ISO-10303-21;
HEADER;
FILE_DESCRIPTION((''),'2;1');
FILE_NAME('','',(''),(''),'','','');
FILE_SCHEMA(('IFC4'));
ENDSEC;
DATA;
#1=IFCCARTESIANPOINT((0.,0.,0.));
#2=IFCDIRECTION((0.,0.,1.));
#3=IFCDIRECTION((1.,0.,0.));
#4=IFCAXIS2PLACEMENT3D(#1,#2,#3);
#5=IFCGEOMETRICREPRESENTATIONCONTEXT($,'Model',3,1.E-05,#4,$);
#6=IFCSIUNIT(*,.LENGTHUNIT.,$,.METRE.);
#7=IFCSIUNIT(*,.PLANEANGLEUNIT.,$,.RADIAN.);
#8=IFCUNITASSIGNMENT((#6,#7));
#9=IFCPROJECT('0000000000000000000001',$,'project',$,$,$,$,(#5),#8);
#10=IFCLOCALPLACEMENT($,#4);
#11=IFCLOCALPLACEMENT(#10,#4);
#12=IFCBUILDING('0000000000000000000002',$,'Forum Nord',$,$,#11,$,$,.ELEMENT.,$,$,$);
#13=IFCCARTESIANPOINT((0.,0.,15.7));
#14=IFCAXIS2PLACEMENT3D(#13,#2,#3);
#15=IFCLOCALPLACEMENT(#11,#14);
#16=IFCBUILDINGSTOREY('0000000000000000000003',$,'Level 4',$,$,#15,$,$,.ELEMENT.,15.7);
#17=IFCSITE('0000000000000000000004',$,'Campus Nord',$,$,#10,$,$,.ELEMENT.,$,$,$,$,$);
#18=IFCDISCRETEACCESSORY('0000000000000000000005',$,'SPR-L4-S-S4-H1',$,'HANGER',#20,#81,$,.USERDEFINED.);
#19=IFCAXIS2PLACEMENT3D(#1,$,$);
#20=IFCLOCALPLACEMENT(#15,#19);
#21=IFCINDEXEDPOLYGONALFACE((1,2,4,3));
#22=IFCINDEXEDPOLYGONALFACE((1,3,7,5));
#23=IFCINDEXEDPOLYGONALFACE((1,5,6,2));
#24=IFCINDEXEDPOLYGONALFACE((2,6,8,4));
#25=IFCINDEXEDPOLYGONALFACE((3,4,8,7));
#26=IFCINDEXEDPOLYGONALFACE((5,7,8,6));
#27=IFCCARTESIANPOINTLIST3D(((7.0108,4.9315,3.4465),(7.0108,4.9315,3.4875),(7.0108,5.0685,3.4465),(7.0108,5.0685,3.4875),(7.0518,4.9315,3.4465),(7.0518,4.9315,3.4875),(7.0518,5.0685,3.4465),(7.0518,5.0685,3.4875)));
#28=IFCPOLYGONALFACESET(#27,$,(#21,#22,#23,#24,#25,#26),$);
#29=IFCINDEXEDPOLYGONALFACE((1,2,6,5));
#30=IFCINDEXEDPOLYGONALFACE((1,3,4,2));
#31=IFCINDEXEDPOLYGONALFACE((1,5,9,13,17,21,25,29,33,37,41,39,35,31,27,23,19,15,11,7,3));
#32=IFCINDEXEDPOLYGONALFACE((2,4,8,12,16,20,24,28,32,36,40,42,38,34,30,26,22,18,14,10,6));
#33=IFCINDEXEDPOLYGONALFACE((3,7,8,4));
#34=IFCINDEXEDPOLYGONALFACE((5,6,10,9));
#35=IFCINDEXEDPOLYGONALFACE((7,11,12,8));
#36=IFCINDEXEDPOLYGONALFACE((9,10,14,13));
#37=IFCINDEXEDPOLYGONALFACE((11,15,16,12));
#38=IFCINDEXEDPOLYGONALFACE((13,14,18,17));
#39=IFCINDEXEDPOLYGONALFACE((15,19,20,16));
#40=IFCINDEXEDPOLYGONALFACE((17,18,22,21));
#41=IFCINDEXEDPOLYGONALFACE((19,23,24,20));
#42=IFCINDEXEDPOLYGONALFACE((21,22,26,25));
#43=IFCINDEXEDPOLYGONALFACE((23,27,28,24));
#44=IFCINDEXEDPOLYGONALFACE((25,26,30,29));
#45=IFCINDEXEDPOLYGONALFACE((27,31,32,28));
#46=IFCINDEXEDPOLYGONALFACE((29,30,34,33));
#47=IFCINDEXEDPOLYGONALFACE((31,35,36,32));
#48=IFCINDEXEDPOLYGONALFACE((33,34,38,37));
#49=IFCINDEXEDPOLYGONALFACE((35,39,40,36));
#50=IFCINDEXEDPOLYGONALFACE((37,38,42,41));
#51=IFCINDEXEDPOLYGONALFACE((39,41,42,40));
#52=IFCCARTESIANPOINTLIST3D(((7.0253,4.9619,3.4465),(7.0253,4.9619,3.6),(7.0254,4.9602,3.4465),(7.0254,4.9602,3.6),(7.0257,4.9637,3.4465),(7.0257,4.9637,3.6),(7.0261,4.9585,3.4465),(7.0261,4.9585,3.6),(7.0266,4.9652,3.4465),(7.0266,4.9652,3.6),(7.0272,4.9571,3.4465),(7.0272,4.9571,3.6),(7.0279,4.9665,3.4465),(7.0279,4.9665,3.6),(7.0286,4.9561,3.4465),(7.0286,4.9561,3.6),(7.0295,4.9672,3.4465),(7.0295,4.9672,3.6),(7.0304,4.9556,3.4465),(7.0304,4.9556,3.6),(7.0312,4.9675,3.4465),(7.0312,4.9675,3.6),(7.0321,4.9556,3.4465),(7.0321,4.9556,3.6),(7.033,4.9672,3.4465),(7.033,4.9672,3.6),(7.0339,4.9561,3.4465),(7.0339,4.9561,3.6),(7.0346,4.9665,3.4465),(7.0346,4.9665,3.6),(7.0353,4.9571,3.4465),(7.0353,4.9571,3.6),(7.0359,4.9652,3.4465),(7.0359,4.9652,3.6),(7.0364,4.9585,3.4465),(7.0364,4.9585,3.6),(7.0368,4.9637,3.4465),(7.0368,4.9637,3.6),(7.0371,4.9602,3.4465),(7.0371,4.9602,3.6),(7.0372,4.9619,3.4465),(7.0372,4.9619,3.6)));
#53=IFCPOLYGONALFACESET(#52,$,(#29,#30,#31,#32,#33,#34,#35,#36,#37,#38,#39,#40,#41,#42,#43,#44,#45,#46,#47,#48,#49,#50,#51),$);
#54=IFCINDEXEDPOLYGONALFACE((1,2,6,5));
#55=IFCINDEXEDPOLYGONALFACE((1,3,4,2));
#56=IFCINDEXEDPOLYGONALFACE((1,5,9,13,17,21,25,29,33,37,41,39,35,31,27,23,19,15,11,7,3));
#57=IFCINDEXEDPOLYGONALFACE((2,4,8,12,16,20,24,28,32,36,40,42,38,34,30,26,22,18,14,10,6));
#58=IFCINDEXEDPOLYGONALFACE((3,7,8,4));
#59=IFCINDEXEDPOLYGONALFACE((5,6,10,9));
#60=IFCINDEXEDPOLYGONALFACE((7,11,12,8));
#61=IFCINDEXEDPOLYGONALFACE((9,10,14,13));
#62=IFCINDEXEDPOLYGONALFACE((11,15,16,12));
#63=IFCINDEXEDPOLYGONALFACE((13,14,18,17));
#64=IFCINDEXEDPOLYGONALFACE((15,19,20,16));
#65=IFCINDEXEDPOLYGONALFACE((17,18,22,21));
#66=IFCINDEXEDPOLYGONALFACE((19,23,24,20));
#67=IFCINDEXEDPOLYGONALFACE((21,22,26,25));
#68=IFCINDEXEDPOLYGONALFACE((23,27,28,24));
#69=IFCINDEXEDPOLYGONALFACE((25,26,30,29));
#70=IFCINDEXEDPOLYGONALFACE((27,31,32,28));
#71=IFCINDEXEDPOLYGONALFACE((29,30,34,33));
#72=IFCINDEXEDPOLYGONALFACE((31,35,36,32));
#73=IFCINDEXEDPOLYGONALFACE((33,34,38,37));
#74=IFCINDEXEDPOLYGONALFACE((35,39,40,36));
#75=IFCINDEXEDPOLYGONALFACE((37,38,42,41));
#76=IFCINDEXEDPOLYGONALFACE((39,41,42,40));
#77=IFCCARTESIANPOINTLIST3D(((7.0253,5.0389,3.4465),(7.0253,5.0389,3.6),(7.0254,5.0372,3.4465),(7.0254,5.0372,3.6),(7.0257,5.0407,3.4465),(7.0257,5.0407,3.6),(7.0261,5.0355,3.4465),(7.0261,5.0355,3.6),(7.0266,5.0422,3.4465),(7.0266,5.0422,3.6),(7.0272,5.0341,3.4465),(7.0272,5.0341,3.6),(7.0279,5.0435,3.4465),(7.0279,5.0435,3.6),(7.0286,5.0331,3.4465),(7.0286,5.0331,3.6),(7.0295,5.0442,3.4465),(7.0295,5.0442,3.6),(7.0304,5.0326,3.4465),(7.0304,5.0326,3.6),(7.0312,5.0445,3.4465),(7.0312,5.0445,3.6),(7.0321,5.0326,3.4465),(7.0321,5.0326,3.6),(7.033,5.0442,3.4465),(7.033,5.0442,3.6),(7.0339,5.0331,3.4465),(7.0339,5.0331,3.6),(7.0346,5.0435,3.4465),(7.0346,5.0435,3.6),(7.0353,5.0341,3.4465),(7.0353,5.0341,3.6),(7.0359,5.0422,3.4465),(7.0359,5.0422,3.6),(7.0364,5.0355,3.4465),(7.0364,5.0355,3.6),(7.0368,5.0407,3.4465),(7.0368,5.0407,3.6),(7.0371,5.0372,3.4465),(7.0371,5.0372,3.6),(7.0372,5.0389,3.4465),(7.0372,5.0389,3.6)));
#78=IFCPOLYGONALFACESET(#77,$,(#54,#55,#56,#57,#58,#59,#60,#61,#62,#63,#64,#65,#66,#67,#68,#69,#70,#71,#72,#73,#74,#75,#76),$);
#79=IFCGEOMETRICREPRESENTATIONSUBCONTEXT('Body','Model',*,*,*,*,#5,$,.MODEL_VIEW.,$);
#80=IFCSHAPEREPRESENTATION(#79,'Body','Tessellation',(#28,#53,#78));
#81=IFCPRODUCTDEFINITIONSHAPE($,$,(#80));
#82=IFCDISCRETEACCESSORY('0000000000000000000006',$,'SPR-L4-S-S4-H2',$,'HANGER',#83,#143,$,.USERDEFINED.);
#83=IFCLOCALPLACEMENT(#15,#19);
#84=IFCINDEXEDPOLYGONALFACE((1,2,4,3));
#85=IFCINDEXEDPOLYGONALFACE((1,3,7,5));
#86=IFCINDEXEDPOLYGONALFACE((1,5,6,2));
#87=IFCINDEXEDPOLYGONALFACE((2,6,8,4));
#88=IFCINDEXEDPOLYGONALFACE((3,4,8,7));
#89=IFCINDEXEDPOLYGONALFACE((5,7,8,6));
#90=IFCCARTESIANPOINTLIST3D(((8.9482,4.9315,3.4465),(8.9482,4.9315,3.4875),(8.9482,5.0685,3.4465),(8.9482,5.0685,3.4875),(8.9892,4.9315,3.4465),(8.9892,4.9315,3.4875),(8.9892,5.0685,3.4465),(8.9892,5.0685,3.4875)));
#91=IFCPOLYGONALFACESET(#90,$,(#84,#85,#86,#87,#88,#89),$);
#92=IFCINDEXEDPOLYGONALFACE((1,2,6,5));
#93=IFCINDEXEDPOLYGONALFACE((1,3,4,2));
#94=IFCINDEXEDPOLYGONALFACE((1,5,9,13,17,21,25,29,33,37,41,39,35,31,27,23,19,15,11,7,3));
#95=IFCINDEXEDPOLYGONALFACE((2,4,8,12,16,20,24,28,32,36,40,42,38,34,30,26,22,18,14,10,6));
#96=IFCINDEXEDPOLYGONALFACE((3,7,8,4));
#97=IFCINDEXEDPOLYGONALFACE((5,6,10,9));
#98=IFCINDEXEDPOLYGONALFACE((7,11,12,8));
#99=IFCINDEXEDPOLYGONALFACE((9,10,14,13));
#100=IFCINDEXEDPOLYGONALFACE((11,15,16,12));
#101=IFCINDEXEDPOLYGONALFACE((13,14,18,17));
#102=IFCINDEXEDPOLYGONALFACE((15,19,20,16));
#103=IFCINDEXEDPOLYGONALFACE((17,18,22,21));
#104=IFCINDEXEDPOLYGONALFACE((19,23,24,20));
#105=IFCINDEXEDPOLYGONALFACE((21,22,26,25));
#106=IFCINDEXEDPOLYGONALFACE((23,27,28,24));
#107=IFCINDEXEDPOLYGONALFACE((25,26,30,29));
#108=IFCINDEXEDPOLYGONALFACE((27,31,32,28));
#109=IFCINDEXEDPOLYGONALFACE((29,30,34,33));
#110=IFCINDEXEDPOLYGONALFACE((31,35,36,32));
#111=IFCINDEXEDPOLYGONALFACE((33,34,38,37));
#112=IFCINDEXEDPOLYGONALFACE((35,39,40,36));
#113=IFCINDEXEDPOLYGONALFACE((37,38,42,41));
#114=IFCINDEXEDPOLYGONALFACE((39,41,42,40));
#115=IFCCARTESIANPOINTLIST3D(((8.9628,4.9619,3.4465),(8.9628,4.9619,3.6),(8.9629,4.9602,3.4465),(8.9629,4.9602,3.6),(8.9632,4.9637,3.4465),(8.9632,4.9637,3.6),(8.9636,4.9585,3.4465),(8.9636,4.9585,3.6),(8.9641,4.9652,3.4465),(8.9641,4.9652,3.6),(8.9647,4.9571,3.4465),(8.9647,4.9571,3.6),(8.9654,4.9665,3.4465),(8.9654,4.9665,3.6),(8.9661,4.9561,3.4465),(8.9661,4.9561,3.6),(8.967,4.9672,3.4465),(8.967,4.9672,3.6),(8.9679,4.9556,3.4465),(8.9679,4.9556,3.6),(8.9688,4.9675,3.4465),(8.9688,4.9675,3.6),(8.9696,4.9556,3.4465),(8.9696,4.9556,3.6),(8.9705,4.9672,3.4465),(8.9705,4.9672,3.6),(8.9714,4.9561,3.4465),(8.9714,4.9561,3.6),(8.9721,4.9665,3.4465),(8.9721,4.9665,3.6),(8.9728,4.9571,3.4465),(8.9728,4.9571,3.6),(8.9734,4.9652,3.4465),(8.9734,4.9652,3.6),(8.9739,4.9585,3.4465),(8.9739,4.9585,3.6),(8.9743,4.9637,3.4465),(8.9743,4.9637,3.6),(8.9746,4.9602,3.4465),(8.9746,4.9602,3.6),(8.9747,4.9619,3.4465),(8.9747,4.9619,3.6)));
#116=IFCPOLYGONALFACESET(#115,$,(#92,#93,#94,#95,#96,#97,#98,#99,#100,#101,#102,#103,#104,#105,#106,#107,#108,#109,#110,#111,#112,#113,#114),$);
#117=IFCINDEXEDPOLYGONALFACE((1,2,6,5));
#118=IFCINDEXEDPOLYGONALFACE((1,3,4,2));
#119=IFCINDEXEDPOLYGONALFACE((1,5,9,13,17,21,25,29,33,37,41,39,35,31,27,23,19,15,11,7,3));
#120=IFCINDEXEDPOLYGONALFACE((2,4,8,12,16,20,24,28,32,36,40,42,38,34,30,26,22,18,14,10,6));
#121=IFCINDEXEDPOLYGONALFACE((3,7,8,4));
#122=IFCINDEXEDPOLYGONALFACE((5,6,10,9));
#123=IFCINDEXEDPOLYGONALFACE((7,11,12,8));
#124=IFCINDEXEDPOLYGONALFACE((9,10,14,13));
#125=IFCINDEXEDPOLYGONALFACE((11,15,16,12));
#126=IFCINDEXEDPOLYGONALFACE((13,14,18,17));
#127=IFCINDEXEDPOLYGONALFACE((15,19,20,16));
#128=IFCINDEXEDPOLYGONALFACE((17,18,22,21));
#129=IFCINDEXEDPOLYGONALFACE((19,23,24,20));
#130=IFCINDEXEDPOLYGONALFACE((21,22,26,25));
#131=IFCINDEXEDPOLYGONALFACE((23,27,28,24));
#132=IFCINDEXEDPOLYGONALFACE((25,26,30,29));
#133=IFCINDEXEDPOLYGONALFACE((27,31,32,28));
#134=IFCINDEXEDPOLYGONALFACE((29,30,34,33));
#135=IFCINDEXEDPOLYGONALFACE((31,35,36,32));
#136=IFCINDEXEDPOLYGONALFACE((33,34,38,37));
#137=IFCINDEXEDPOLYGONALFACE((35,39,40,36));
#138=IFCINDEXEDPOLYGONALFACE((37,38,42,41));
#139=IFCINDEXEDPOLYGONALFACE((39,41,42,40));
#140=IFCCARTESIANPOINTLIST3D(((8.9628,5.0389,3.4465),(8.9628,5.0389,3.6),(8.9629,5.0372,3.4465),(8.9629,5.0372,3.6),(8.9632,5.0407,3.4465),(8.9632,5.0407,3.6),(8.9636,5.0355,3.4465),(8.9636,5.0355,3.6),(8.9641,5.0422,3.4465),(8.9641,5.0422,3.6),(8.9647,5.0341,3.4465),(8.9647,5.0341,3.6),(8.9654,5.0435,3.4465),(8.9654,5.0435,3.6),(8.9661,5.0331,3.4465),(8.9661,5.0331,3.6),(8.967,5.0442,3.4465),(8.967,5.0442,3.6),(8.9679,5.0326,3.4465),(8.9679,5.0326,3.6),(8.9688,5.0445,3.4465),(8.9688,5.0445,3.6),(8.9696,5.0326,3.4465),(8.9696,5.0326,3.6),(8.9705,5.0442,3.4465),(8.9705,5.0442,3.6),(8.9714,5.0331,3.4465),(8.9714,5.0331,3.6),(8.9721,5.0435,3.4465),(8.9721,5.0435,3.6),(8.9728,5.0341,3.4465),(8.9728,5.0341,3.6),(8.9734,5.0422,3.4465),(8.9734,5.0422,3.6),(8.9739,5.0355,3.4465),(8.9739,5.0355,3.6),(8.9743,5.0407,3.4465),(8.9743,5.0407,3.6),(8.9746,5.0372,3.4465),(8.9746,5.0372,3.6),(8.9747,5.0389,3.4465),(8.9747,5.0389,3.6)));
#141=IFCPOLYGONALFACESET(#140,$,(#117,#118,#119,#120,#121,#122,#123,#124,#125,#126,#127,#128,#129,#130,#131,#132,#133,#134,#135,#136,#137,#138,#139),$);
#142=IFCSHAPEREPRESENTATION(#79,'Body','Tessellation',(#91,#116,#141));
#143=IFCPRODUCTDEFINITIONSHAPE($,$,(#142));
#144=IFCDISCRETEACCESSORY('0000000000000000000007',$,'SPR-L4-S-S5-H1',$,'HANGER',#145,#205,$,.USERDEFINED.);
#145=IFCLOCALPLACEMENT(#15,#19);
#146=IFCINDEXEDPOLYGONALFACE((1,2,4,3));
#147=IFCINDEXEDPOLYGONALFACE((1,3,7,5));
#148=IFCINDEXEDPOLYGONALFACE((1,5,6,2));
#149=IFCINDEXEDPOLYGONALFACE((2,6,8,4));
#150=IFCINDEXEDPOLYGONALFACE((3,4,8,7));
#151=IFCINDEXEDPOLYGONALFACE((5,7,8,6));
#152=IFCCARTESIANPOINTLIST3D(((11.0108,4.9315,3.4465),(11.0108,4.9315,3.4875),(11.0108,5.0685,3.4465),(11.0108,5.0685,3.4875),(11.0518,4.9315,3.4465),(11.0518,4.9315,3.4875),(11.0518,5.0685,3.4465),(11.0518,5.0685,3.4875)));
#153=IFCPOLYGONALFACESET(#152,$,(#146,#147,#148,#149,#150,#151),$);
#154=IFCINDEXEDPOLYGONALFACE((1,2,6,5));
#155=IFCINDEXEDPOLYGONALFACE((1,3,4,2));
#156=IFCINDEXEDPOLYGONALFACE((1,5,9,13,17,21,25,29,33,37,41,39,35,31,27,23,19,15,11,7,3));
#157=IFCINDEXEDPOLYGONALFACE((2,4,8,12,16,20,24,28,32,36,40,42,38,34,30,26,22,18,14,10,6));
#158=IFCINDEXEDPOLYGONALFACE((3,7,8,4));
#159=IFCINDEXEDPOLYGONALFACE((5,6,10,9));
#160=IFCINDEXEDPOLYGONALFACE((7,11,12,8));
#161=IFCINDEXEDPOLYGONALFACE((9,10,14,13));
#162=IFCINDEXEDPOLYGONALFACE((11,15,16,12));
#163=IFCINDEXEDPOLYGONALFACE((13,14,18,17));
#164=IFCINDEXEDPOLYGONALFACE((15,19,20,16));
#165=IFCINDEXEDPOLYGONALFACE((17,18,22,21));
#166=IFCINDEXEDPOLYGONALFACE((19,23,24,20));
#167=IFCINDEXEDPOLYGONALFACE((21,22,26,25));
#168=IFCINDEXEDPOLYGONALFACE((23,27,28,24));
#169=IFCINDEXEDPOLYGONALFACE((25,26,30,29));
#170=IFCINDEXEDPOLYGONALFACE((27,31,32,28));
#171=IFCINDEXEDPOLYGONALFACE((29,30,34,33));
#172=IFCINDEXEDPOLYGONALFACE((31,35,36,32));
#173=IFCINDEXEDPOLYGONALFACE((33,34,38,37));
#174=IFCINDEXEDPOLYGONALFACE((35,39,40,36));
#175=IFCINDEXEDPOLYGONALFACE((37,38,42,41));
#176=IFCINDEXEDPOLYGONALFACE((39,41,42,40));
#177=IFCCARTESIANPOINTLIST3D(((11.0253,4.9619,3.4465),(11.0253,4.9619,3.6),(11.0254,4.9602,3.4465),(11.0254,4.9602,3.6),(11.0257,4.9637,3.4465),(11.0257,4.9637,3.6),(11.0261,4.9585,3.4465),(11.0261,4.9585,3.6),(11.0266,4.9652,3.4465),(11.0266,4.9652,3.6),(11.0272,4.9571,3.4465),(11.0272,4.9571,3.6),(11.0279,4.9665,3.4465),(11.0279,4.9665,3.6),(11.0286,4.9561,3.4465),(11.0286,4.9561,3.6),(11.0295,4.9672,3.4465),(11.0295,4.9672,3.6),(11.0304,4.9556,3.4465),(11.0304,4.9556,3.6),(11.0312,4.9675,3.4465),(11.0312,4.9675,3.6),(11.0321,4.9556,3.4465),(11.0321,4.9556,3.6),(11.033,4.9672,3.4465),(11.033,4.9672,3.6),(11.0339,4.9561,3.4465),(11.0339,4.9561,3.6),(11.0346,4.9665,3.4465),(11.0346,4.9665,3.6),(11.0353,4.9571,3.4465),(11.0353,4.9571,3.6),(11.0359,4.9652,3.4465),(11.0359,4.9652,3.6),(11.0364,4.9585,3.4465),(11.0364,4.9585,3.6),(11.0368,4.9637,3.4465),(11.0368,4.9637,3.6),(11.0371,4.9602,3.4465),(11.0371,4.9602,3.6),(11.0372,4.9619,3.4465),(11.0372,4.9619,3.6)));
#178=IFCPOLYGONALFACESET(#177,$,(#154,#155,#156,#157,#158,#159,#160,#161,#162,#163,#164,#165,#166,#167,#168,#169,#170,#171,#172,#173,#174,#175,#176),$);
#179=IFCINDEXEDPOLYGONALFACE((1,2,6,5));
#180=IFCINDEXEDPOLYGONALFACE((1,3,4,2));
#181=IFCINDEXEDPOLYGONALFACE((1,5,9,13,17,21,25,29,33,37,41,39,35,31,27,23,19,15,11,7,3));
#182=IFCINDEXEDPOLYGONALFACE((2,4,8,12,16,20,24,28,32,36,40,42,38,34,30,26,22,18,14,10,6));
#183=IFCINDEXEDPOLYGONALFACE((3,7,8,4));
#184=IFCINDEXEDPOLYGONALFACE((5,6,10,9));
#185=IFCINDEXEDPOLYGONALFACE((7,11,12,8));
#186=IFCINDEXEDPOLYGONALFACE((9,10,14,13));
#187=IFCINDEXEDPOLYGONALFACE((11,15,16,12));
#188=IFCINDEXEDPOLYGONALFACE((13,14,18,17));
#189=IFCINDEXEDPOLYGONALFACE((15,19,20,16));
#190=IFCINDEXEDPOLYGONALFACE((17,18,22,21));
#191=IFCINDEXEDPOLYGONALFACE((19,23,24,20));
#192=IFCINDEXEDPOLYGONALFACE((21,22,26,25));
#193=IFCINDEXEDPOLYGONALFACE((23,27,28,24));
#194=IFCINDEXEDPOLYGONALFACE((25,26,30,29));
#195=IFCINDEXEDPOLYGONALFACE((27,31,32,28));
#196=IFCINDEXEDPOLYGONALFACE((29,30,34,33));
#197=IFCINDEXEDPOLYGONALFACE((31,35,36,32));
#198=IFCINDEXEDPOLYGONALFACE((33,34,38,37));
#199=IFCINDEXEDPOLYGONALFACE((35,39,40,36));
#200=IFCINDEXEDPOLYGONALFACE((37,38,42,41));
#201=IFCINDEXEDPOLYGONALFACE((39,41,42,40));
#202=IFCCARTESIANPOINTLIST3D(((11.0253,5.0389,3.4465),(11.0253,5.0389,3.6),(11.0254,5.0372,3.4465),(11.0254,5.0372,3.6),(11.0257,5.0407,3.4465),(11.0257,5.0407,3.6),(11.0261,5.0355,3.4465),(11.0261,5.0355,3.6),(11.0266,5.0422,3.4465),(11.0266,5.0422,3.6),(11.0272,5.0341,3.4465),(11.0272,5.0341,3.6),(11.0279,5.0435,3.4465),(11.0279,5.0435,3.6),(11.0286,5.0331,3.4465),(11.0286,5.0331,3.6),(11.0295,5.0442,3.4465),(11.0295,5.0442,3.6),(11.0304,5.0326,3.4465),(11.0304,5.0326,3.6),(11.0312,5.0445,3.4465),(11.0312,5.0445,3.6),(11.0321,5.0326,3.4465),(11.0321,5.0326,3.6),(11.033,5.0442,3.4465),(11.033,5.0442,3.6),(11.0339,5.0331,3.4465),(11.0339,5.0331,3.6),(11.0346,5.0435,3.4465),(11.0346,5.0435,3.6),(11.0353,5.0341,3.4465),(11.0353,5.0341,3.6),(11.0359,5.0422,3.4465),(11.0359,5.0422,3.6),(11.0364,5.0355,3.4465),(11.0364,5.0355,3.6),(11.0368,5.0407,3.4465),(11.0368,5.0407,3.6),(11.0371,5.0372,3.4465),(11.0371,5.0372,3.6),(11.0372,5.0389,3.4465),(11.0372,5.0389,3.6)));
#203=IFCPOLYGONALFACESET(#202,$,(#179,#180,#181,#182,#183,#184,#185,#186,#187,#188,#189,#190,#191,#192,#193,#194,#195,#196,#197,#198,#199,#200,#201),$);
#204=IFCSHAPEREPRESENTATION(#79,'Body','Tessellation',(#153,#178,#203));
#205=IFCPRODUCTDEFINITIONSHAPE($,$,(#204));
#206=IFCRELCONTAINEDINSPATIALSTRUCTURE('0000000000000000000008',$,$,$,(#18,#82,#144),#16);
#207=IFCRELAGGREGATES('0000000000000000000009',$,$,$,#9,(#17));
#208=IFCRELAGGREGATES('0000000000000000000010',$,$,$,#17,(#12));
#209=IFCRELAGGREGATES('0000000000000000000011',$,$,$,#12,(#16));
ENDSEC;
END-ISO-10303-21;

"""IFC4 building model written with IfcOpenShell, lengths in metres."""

from ifc_helpers import new_model, si_unit, frame, frame_2d, origin_with_axes, origin_2d_with_axis, place, context, subcontext, project, spatial, rectangle, circle, extrude, element, save


model = new_model("IFC4")

# Units and contexts
model_context = context("Model", 3, precision=1e-05, world=origin_with_axes())
body_context = subcontext(model_context, "Body", "Model", "MODEL_VIEW")
ifc_project = project(units=[si_unit("LENGTHUNIT", "METRE"), si_unit("PLANEANGLEUNIT", "RADIAN")], contexts=[model_context])

# Site, building, storey
site_placement = place(None, origin_with_axes())
site = spatial("IfcSite", under=ifc_project, at=site_placement, Name="Campus Nord", CompositionType="ELEMENT")
building_placement = place(site_placement, origin_with_axes())
building = spatial("IfcBuilding", under=site, at=building_placement, Name="Forum Nord", CompositionType="ELEMENT")
storey_placement = place(building_placement, frame((0.0, 0.0, 15.7), z_axis=(0.0, 0.0, 1.0), x_axis=(1.0, 0.0, 0.0)))
storey = spatial("IfcBuildingStorey", under=building, at=storey_placement, Name="Level 4", CompositionType="ELEMENT", Elevation=15.7)

# Discrete accessories
for number, where, z_axis, x_axis, name in (
    (1, (7.0312, 5.0, 3.4875), (0.0, 0.0, 1.0), (0.0, 1.0, 0.0), "SPR-L4-S-S4-H1"),
    (2, (8.9688, 5.0, 3.4875), (0.0, 0.0, 1.0), (0.0, 1.0, 0.0), "SPR-L4-S-S4-H2"),
    (3, (11.0312, 5.0, 3.4875), (0.0, 0.0, 1.0), (0.0, 1.0, 0.0), "SPR-L4-S-S5-H1"),
):
    element("IfcDiscreteAccessory", number, at=place(storey_placement, frame(where, z_axis=z_axis, x_axis=x_axis)), inside=storey, Name=name, ObjectType="HANGER", PredefinedType="USERDEFINED", context=body_context, shape_type="SweptSolid", body=[
        extrude(rectangle(XDim=0.137, YDim=0.041, at=origin_2d_with_axis()), frame((0.0, 0.0, -0.041), z_axis=(0.0, 0.0, 1.0), x_axis=(1.0, 0.0, 0.0)), (0.0, 0.0, 1.0), 0.041),
        extrude(circle(Radius=0.006, at=frame_2d((-0.0385, 0.0), x_axis=(1.0, 0.0))), frame((0.0, 0.0, -0.041), z_axis=(0.0, 0.0, 1.0), x_axis=(1.0, 0.0, 0.0)), (0.0, 0.0, 1.0), 0.1535),
        extrude(circle(Radius=0.006, at=frame_2d((0.0385, 0.0), x_axis=(1.0, 0.0))), frame((0.0, 0.0, -0.041), z_axis=(0.0, 0.0, 1.0), x_axis=(1.0, 0.0, 0.0)), (0.0, 0.0, 1.0), 0.1535),
    ])

save(model, "model.ifc")
